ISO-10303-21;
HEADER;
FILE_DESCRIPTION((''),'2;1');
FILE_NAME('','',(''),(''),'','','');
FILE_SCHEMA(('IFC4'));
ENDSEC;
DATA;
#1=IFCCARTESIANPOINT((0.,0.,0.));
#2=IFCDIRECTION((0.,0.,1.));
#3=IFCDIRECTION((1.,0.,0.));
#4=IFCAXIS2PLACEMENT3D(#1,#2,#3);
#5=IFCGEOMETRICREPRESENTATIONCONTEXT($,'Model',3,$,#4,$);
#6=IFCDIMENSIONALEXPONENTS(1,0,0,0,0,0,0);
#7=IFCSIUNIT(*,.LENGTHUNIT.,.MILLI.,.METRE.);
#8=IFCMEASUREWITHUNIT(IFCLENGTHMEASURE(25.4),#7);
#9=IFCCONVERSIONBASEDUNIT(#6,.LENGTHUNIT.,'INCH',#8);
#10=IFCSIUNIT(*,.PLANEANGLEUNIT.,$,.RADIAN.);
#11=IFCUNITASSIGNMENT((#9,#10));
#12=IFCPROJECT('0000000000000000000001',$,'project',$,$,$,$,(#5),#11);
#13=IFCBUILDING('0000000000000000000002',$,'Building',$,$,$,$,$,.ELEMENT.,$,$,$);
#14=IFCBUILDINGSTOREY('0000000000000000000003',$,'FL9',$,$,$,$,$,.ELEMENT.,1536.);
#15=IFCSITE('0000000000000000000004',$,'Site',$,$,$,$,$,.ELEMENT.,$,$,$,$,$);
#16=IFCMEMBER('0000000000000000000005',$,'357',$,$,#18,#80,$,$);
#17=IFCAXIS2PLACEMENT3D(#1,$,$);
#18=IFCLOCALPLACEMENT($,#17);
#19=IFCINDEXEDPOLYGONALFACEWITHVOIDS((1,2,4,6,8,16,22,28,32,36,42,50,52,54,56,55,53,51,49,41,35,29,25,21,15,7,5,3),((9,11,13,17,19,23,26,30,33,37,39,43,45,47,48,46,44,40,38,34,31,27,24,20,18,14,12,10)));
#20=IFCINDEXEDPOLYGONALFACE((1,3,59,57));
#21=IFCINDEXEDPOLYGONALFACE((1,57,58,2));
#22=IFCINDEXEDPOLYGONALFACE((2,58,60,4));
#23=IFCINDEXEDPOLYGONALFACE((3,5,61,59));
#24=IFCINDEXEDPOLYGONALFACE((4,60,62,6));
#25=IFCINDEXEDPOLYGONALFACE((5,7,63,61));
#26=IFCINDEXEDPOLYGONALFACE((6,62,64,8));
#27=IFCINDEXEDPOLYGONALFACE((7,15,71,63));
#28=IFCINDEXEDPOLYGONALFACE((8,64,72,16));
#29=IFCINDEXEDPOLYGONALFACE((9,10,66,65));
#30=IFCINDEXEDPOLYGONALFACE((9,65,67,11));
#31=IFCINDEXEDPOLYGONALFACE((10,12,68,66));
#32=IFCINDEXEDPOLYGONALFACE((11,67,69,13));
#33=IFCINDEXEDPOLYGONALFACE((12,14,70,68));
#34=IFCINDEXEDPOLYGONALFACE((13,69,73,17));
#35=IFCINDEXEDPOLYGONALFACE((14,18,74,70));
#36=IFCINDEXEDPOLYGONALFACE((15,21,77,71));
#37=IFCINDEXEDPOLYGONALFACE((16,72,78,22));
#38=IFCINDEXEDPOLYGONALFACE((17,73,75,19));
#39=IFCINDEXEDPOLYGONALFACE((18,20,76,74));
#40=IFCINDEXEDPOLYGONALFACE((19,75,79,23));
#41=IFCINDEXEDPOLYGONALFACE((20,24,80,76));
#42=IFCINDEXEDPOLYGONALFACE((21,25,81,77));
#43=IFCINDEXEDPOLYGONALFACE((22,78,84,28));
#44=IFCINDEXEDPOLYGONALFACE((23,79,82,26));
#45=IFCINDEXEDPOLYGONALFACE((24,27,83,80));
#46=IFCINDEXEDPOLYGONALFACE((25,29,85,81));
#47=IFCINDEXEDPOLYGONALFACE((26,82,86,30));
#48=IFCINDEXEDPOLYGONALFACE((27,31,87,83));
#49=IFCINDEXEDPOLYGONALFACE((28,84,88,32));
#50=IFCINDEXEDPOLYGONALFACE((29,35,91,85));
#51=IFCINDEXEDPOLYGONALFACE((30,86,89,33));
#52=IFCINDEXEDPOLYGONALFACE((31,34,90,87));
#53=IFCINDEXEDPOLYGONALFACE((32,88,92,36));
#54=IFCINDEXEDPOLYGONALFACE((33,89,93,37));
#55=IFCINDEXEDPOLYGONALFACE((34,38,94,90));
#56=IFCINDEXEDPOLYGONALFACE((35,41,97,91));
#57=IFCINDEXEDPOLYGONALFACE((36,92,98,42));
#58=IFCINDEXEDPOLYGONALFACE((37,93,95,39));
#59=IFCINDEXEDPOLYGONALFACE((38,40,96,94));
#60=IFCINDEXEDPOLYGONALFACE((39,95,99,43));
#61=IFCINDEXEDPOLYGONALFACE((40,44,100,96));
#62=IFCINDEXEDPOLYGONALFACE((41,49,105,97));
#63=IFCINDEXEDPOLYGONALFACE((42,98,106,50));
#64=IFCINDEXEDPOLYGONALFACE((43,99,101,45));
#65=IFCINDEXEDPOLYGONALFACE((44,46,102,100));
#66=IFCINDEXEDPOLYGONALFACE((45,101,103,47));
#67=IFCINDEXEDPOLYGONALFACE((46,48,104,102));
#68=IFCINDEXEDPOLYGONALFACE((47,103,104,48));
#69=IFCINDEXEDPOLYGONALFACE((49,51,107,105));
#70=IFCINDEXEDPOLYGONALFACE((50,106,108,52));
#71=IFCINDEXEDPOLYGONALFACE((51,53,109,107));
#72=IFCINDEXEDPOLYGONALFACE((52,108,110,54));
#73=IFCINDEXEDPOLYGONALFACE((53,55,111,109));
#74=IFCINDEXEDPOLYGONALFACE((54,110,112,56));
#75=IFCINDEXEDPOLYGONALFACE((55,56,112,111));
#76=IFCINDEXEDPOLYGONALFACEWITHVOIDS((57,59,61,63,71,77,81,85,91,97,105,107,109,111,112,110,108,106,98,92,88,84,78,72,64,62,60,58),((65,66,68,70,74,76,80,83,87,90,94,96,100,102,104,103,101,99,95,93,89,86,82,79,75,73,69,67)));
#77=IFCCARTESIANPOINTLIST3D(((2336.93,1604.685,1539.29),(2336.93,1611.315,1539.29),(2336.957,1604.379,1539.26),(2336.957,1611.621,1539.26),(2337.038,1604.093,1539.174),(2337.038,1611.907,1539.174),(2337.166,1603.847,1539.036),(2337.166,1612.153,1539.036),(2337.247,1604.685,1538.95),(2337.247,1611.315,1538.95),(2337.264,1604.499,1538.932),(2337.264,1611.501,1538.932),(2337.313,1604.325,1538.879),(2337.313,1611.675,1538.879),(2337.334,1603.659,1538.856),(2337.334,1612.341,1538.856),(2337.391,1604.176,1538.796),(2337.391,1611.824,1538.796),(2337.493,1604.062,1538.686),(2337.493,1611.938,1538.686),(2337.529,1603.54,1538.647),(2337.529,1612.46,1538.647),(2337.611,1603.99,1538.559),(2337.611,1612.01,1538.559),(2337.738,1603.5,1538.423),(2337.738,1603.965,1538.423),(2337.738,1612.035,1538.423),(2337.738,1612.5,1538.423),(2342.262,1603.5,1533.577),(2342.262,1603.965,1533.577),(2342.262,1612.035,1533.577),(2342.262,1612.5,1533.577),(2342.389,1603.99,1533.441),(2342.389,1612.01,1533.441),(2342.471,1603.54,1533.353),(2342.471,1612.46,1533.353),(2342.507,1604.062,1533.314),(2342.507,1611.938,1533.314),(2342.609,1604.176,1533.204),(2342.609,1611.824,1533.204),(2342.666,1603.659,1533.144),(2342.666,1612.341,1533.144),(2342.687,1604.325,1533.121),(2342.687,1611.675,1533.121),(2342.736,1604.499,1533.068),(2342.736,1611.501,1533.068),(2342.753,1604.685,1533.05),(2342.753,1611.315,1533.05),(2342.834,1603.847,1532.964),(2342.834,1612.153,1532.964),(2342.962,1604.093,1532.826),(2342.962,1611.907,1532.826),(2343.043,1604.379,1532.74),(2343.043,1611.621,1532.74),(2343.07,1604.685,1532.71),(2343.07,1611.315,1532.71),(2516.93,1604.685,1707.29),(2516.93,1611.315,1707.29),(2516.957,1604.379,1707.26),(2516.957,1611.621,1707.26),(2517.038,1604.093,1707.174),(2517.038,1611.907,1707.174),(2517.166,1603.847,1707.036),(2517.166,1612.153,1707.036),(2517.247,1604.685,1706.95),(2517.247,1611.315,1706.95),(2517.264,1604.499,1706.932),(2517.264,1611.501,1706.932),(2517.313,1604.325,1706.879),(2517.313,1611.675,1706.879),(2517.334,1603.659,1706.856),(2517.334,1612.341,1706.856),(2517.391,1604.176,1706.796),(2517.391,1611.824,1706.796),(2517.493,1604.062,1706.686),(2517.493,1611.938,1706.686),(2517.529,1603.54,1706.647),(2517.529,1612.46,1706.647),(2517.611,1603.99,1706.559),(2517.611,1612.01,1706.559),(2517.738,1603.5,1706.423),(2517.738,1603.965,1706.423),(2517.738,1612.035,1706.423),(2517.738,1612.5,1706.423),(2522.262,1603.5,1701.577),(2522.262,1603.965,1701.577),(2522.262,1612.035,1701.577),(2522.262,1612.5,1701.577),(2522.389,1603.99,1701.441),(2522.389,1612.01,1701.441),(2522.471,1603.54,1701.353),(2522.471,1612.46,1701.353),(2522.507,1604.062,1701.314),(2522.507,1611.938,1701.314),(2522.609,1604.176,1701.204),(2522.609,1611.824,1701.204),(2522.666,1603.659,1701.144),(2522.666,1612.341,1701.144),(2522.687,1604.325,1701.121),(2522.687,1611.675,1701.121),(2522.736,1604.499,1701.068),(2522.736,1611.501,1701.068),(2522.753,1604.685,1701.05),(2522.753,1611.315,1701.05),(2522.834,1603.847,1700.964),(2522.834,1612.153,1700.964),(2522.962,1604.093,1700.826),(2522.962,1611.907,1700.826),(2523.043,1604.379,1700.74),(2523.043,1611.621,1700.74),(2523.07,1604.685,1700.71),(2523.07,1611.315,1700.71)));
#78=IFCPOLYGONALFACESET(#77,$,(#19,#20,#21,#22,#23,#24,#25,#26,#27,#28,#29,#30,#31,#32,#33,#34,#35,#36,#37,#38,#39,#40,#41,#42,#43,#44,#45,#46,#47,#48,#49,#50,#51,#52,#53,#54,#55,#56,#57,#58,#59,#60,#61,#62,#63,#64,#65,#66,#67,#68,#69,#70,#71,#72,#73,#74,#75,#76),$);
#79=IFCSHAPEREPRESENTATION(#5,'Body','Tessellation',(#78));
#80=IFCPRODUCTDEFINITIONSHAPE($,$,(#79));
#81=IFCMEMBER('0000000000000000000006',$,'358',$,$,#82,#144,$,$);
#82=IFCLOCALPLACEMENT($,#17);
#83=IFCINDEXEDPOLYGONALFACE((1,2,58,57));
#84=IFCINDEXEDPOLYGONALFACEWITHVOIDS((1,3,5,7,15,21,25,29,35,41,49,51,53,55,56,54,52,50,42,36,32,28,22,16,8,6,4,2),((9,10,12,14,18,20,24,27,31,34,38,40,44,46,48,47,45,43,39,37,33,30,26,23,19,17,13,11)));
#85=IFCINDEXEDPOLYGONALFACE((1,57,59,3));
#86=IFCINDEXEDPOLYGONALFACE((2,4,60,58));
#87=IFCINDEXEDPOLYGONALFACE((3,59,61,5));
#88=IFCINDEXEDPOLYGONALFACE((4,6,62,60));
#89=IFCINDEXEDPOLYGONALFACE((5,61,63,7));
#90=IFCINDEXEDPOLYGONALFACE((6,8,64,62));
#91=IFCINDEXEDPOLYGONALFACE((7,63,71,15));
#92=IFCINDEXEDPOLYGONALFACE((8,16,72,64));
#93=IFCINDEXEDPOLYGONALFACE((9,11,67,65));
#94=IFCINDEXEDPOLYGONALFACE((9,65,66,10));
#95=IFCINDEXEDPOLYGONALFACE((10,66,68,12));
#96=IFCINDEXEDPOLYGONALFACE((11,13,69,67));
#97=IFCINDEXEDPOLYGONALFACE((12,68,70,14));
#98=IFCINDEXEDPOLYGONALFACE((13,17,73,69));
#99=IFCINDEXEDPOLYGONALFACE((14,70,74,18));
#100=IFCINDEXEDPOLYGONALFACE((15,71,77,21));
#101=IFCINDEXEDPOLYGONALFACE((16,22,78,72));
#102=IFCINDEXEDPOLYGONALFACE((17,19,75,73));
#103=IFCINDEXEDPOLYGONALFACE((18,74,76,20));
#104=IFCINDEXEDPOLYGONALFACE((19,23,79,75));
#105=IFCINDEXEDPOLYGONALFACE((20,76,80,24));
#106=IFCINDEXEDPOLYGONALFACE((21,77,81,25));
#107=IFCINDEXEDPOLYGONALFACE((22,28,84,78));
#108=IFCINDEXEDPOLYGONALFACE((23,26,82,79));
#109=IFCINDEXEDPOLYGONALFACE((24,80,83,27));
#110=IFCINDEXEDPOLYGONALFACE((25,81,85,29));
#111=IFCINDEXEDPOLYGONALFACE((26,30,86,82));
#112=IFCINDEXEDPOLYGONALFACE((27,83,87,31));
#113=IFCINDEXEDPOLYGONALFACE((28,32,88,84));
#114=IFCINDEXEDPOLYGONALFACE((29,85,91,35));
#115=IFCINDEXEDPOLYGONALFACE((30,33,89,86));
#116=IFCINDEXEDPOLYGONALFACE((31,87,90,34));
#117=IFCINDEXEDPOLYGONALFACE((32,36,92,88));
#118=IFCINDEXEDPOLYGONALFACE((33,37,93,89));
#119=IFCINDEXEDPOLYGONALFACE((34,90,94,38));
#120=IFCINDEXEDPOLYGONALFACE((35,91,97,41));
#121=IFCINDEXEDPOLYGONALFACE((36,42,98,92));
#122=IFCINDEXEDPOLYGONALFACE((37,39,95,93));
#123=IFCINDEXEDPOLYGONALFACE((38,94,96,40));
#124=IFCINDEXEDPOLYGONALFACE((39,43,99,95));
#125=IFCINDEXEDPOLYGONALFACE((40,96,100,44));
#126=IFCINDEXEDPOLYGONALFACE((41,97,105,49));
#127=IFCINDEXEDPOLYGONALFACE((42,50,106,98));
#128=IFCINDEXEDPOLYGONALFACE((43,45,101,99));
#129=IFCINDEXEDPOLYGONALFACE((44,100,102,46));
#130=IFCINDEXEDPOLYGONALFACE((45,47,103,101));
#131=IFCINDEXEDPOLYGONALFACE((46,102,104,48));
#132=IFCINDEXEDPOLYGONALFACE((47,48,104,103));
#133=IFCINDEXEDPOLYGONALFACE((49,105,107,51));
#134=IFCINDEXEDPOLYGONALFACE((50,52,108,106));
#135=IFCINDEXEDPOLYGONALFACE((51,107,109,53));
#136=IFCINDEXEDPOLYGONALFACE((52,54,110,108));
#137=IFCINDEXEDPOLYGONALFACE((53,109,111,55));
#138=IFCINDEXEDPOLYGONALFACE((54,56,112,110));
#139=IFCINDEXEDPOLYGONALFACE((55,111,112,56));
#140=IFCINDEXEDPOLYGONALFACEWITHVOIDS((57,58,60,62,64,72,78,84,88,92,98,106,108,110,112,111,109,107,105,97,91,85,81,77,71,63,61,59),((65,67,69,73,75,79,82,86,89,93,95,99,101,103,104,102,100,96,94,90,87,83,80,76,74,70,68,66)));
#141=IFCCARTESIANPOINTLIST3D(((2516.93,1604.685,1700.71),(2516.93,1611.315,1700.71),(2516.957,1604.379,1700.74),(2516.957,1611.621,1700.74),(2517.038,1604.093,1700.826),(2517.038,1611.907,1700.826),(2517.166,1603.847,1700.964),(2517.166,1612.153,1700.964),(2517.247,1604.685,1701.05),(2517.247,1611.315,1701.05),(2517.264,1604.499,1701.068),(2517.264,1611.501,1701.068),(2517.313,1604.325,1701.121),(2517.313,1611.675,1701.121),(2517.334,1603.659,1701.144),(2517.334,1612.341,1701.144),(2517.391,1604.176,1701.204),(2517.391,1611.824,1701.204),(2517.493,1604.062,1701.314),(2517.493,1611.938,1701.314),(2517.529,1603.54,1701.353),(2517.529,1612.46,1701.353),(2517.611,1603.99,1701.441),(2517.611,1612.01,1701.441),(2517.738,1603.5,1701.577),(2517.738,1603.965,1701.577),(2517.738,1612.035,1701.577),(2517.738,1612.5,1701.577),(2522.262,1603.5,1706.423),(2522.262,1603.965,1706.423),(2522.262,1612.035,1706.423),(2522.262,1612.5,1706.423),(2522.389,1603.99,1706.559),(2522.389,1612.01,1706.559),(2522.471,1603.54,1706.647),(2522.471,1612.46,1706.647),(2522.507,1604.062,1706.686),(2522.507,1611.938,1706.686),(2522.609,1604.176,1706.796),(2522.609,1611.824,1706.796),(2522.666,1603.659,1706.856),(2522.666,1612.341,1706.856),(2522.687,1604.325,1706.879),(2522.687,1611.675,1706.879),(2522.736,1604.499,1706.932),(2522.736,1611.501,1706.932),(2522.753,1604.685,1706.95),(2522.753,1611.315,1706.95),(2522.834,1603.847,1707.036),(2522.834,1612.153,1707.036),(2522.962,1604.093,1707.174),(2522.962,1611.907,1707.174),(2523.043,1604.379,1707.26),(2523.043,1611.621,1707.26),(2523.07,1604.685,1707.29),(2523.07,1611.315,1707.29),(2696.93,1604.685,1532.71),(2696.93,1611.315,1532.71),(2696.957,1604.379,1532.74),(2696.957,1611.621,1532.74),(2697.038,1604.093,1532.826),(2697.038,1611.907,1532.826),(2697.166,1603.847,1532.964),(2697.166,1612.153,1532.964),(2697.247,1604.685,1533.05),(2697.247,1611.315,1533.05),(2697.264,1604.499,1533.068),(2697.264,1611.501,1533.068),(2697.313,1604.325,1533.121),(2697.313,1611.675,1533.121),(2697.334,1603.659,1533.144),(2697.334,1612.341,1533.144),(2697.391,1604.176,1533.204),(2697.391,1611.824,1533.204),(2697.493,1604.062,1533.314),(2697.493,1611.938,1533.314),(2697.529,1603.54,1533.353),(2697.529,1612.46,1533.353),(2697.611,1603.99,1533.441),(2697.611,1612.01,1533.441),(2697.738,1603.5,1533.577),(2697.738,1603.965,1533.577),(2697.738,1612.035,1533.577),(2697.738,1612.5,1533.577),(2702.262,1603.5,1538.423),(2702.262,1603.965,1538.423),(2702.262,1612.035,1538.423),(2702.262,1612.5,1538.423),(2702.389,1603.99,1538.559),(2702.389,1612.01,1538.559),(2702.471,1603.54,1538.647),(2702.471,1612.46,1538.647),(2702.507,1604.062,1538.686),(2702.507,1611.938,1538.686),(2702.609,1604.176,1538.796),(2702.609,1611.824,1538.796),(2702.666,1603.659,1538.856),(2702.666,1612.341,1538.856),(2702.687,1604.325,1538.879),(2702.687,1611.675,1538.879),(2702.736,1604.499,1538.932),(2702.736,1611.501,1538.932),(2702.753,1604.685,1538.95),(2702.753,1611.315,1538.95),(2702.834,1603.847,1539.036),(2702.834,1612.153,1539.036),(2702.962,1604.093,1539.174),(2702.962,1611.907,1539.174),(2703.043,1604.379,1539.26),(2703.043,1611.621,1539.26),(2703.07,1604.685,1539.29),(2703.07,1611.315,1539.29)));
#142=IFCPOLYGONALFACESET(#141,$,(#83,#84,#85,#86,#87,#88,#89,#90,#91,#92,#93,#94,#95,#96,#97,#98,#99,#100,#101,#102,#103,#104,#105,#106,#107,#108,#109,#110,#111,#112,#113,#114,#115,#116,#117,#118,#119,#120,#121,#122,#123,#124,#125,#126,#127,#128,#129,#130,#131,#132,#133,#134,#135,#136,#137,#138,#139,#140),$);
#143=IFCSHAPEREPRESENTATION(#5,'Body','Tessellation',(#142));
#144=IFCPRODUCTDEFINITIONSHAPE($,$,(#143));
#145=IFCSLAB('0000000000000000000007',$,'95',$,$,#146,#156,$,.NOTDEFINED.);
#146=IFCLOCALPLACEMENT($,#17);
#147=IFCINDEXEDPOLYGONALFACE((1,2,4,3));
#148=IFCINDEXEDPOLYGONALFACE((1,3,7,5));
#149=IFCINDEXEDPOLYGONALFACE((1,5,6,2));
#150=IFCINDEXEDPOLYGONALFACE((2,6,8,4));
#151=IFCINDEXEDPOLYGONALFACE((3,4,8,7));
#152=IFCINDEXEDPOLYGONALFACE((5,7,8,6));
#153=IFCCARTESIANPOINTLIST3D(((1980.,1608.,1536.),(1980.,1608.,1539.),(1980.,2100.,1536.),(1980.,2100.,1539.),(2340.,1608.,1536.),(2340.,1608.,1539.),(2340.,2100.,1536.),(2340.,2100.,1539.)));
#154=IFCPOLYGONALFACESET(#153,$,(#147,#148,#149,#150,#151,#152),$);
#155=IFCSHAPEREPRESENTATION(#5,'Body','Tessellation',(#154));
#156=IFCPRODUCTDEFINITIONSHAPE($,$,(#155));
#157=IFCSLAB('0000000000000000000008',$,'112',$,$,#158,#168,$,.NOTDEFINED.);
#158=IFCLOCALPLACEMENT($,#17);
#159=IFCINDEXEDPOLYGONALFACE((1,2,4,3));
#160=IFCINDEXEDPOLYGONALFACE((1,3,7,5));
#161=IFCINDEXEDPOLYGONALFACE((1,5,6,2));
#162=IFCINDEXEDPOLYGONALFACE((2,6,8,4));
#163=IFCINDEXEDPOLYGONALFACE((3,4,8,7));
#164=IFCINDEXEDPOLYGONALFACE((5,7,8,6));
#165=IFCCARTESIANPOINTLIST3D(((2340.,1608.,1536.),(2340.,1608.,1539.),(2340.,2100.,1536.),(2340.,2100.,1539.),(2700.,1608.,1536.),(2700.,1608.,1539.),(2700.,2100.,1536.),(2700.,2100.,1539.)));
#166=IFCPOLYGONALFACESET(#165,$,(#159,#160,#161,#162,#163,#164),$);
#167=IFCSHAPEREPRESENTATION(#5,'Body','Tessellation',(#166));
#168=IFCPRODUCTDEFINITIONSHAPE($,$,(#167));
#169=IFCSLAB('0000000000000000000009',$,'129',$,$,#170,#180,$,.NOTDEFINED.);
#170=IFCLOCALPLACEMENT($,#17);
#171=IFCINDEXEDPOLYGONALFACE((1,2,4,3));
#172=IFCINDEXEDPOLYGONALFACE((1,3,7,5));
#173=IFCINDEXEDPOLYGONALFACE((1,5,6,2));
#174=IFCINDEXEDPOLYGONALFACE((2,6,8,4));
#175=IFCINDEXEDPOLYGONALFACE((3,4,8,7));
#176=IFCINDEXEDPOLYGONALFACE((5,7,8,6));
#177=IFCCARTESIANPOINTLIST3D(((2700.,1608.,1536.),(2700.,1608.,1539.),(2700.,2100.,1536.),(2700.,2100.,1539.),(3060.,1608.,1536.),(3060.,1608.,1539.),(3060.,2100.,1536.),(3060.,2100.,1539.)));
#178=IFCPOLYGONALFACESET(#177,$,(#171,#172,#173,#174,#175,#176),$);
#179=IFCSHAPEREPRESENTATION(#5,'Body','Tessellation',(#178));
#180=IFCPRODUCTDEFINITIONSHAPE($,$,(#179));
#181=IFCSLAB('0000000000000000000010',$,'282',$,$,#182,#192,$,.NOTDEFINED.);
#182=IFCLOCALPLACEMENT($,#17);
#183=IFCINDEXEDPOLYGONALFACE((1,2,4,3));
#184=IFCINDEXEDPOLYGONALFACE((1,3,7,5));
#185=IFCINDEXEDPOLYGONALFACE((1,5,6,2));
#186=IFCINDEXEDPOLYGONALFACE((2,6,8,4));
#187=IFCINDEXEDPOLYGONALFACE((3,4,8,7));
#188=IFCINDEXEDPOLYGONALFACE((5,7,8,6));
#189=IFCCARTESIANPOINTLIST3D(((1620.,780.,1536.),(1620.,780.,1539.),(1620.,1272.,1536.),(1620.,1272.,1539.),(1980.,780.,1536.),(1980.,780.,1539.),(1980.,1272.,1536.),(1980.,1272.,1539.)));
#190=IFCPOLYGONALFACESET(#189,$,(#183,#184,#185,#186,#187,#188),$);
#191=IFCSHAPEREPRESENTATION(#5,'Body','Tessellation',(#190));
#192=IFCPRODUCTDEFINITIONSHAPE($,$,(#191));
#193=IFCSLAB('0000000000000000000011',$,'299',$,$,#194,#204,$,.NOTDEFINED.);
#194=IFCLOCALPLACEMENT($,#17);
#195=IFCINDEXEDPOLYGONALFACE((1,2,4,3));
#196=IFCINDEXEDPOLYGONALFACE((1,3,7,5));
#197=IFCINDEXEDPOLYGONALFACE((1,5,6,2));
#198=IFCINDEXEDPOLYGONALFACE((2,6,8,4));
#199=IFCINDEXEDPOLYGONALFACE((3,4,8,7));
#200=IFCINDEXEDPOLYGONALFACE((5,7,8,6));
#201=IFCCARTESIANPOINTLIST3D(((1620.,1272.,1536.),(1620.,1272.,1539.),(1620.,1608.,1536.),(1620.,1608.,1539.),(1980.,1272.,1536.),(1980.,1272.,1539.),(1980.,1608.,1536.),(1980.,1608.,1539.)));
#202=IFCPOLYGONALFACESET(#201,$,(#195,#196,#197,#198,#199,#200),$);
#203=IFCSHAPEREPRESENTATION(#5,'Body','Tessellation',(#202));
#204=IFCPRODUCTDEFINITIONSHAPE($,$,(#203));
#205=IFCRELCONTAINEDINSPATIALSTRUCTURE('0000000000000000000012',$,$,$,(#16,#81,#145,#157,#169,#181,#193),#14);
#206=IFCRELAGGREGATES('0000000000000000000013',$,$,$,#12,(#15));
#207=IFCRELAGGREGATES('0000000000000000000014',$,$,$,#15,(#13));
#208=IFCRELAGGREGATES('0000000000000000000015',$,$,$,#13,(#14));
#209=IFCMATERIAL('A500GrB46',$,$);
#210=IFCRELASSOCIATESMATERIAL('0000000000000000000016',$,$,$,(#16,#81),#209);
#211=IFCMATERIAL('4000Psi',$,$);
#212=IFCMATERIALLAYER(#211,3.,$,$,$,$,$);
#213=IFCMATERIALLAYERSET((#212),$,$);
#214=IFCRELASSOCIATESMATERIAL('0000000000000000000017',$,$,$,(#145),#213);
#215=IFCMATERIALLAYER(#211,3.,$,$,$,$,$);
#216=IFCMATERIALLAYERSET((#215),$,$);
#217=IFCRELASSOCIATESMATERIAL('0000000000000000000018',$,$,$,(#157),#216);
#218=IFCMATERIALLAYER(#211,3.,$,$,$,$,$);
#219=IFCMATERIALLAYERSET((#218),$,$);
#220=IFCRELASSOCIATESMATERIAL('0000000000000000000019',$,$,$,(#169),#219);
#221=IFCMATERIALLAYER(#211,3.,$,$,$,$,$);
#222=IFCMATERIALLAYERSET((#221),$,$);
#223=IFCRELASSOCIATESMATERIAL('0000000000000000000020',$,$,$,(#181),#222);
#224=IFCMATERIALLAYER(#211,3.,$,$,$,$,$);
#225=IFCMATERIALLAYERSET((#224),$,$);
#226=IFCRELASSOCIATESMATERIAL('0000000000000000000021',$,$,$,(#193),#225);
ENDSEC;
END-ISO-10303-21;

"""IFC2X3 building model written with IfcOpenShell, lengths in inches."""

from ifc_helpers import new_model, entity, si_unit, converted_unit, frame, origin_with_axes, origin_2d_with_axis, place, context, project, spatial, polyline, hollow_rectangle, outline, extrude, material, layer, layer_set, layer_usage, element, save


model = new_model("IFC2X3")

# Units and contexts
model_context = context("Model", 3, world=origin_with_axes())
ifc_project = project(units=[converted_unit("LENGTHUNIT", "INCH", entity("IfcLengthMeasure", 25.4), si_unit("LENGTHUNIT", "METRE", prefix="MILLI"), dimensions=[1, 0, 0, 0, 0, 0, 0]), si_unit("PLANEANGLEUNIT", "RADIAN")], contexts=[model_context])

# Site, building, storey
site = spatial("IfcSite", under=ifc_project, Name="Site", CompositionType="ELEMENT")
building = spatial("IfcBuilding", under=site, Name="Building", CompositionType="ELEMENT")
storey = spatial("IfcBuildingStorey", under=building, Name="FL9", CompositionType="ELEMENT", Elevation=1536.0)

# Members
ifc_material_1 = material(Name="A500GrB46")
for number, where, z_axis, x_axis, name in (
    (1, (2340.0, 1608.0, 1536.0), (0.731055, 0.0, 0.682318), (0.0, 1.0, 0.0), "357"),
    (2, (2700.0, 1608.0, 1536.0), (-0.731055, 0.0, 0.682318), (0.0, -1.0, 0.0), "358"),
):
    element("IfcMember", number, at=place(None, frame(where, z_axis=z_axis, x_axis=x_axis)), inside=storey, material=ifc_material_1, Name=name, context=model_context, shape_type="SweptSolid", body=[
        extrude(hollow_rectangle(XDim=9.0, YDim=9.0, WallThickness=0.465, InnerFilletRadius=0.72, OuterFilletRadius=1.185, at=origin_2d_with_axis()), origin_with_axes(), (0.0, 0.0, 1.0), 246.219),
    ])

# Slabs
ifc_material_2 = material(Name="4000Psi")
ifc_layer_1 = layer(ifc_material_2, 3.0)
ifc_layer_set_1 = layer_set([ifc_layer_1])
ifc_layer_usage_1 = layer_usage(ifc_layer_set_1, "AXIS2", "POSITIVE", -3.0)
slab_1_placement = place(None, frame((1980.0, 1608.0, 1536.0), z_axis=(0.0, 0.0, 1.0), x_axis=(1.0, 0.0, 0.0)))
element("IfcSlab", 3, at=slab_1_placement, inside=storey, material=ifc_layer_usage_1, Name="95", PredefinedType="NOTDEFINED", context=model_context, shape_type="SweptSolid", body=[
    extrude(outline(polyline([(0.0, 0.0), (360.0, 0.0), (360.0, 492.0), (0.0, 492.0), (0.0, 0.0)])), origin_with_axes(), (0.0, 0.0, 1.0), 3.0),
])
ifc_layer_2 = layer(ifc_material_2, 3.0)
ifc_layer_set_2 = layer_set([ifc_layer_2])
ifc_layer_usage_2 = layer_usage(ifc_layer_set_2, "AXIS2", "POSITIVE", -3.0)
slab_2_placement = place(None, frame((2340.0, 1608.0, 1536.0), z_axis=(0.0, 0.0, 1.0), x_axis=(1.0, 0.0, 0.0)))
element("IfcSlab", 4, at=slab_2_placement, inside=storey, material=ifc_layer_usage_2, Name="112", PredefinedType="NOTDEFINED", context=model_context, shape_type="SweptSolid", body=[
    extrude(outline(polyline([(0.0, 0.0), (360.0, 0.0), (360.0, 492.0), (0.0, 492.0), (0.0, 0.0)])), origin_with_axes(), (0.0, 0.0, 1.0), 3.0),
])
ifc_layer_3 = layer(ifc_material_2, 3.0)
ifc_layer_set_3 = layer_set([ifc_layer_3])
ifc_layer_usage_3 = layer_usage(ifc_layer_set_3, "AXIS2", "POSITIVE", -3.0)
slab_3_placement = place(None, frame((2700.0, 1608.0, 1536.0), z_axis=(0.0, 0.0, 1.0), x_axis=(1.0, 0.0, 0.0)))
element("IfcSlab", 5, at=slab_3_placement, inside=storey, material=ifc_layer_usage_3, Name="129", PredefinedType="NOTDEFINED", context=model_context, shape_type="SweptSolid", body=[
    extrude(outline(polyline([(0.0, 0.0), (360.0, 0.0), (360.0, 492.0), (0.0, 492.0), (0.0, 0.0)])), origin_with_axes(), (0.0, 0.0, 1.0), 3.0),
])
ifc_layer_4 = layer(ifc_material_2, 3.0)
ifc_layer_set_4 = layer_set([ifc_layer_4])
ifc_layer_usage_4 = layer_usage(ifc_layer_set_4, "AXIS2", "POSITIVE", -3.0)
slab_4_placement = place(None, frame((1620.0, 780.0, 1536.0), z_axis=(0.0, 0.0, 1.0), x_axis=(1.0, 0.0, 0.0)))
element("IfcSlab", 6, at=slab_4_placement, inside=storey, material=ifc_layer_usage_4, Name="282", PredefinedType="NOTDEFINED", context=model_context, shape_type="SweptSolid", body=[
    extrude(outline(polyline([(0.0, 0.0), (360.0, 0.0), (360.0, 492.0), (0.0, 492.0), (0.0, 0.0)])), origin_with_axes(), (0.0, 0.0, 1.0), 3.0),
])
ifc_layer_5 = layer(ifc_material_2, 3.0)
ifc_layer_set_5 = layer_set([ifc_layer_5])
ifc_layer_usage_5 = layer_usage(ifc_layer_set_5, "AXIS2", "POSITIVE", -3.0)
slab_5_placement = place(None, frame((1620.0, 1272.0, 1536.0), z_axis=(0.0, 0.0, 1.0), x_axis=(1.0, 0.0, 0.0)))
element("IfcSlab", 7, at=slab_5_placement, inside=storey, material=ifc_layer_usage_5, Name="299", PredefinedType="NOTDEFINED", context=model_context, shape_type="SweptSolid", body=[
    extrude(outline(polyline([(0.0, 0.0), (360.0, 0.0), (360.0, 336.0), (0.0, 336.0), (0.0, 0.0)])), origin_with_axes(), (0.0, 0.0, 1.0), 3.0),
])

save(model, "model.ifc")
